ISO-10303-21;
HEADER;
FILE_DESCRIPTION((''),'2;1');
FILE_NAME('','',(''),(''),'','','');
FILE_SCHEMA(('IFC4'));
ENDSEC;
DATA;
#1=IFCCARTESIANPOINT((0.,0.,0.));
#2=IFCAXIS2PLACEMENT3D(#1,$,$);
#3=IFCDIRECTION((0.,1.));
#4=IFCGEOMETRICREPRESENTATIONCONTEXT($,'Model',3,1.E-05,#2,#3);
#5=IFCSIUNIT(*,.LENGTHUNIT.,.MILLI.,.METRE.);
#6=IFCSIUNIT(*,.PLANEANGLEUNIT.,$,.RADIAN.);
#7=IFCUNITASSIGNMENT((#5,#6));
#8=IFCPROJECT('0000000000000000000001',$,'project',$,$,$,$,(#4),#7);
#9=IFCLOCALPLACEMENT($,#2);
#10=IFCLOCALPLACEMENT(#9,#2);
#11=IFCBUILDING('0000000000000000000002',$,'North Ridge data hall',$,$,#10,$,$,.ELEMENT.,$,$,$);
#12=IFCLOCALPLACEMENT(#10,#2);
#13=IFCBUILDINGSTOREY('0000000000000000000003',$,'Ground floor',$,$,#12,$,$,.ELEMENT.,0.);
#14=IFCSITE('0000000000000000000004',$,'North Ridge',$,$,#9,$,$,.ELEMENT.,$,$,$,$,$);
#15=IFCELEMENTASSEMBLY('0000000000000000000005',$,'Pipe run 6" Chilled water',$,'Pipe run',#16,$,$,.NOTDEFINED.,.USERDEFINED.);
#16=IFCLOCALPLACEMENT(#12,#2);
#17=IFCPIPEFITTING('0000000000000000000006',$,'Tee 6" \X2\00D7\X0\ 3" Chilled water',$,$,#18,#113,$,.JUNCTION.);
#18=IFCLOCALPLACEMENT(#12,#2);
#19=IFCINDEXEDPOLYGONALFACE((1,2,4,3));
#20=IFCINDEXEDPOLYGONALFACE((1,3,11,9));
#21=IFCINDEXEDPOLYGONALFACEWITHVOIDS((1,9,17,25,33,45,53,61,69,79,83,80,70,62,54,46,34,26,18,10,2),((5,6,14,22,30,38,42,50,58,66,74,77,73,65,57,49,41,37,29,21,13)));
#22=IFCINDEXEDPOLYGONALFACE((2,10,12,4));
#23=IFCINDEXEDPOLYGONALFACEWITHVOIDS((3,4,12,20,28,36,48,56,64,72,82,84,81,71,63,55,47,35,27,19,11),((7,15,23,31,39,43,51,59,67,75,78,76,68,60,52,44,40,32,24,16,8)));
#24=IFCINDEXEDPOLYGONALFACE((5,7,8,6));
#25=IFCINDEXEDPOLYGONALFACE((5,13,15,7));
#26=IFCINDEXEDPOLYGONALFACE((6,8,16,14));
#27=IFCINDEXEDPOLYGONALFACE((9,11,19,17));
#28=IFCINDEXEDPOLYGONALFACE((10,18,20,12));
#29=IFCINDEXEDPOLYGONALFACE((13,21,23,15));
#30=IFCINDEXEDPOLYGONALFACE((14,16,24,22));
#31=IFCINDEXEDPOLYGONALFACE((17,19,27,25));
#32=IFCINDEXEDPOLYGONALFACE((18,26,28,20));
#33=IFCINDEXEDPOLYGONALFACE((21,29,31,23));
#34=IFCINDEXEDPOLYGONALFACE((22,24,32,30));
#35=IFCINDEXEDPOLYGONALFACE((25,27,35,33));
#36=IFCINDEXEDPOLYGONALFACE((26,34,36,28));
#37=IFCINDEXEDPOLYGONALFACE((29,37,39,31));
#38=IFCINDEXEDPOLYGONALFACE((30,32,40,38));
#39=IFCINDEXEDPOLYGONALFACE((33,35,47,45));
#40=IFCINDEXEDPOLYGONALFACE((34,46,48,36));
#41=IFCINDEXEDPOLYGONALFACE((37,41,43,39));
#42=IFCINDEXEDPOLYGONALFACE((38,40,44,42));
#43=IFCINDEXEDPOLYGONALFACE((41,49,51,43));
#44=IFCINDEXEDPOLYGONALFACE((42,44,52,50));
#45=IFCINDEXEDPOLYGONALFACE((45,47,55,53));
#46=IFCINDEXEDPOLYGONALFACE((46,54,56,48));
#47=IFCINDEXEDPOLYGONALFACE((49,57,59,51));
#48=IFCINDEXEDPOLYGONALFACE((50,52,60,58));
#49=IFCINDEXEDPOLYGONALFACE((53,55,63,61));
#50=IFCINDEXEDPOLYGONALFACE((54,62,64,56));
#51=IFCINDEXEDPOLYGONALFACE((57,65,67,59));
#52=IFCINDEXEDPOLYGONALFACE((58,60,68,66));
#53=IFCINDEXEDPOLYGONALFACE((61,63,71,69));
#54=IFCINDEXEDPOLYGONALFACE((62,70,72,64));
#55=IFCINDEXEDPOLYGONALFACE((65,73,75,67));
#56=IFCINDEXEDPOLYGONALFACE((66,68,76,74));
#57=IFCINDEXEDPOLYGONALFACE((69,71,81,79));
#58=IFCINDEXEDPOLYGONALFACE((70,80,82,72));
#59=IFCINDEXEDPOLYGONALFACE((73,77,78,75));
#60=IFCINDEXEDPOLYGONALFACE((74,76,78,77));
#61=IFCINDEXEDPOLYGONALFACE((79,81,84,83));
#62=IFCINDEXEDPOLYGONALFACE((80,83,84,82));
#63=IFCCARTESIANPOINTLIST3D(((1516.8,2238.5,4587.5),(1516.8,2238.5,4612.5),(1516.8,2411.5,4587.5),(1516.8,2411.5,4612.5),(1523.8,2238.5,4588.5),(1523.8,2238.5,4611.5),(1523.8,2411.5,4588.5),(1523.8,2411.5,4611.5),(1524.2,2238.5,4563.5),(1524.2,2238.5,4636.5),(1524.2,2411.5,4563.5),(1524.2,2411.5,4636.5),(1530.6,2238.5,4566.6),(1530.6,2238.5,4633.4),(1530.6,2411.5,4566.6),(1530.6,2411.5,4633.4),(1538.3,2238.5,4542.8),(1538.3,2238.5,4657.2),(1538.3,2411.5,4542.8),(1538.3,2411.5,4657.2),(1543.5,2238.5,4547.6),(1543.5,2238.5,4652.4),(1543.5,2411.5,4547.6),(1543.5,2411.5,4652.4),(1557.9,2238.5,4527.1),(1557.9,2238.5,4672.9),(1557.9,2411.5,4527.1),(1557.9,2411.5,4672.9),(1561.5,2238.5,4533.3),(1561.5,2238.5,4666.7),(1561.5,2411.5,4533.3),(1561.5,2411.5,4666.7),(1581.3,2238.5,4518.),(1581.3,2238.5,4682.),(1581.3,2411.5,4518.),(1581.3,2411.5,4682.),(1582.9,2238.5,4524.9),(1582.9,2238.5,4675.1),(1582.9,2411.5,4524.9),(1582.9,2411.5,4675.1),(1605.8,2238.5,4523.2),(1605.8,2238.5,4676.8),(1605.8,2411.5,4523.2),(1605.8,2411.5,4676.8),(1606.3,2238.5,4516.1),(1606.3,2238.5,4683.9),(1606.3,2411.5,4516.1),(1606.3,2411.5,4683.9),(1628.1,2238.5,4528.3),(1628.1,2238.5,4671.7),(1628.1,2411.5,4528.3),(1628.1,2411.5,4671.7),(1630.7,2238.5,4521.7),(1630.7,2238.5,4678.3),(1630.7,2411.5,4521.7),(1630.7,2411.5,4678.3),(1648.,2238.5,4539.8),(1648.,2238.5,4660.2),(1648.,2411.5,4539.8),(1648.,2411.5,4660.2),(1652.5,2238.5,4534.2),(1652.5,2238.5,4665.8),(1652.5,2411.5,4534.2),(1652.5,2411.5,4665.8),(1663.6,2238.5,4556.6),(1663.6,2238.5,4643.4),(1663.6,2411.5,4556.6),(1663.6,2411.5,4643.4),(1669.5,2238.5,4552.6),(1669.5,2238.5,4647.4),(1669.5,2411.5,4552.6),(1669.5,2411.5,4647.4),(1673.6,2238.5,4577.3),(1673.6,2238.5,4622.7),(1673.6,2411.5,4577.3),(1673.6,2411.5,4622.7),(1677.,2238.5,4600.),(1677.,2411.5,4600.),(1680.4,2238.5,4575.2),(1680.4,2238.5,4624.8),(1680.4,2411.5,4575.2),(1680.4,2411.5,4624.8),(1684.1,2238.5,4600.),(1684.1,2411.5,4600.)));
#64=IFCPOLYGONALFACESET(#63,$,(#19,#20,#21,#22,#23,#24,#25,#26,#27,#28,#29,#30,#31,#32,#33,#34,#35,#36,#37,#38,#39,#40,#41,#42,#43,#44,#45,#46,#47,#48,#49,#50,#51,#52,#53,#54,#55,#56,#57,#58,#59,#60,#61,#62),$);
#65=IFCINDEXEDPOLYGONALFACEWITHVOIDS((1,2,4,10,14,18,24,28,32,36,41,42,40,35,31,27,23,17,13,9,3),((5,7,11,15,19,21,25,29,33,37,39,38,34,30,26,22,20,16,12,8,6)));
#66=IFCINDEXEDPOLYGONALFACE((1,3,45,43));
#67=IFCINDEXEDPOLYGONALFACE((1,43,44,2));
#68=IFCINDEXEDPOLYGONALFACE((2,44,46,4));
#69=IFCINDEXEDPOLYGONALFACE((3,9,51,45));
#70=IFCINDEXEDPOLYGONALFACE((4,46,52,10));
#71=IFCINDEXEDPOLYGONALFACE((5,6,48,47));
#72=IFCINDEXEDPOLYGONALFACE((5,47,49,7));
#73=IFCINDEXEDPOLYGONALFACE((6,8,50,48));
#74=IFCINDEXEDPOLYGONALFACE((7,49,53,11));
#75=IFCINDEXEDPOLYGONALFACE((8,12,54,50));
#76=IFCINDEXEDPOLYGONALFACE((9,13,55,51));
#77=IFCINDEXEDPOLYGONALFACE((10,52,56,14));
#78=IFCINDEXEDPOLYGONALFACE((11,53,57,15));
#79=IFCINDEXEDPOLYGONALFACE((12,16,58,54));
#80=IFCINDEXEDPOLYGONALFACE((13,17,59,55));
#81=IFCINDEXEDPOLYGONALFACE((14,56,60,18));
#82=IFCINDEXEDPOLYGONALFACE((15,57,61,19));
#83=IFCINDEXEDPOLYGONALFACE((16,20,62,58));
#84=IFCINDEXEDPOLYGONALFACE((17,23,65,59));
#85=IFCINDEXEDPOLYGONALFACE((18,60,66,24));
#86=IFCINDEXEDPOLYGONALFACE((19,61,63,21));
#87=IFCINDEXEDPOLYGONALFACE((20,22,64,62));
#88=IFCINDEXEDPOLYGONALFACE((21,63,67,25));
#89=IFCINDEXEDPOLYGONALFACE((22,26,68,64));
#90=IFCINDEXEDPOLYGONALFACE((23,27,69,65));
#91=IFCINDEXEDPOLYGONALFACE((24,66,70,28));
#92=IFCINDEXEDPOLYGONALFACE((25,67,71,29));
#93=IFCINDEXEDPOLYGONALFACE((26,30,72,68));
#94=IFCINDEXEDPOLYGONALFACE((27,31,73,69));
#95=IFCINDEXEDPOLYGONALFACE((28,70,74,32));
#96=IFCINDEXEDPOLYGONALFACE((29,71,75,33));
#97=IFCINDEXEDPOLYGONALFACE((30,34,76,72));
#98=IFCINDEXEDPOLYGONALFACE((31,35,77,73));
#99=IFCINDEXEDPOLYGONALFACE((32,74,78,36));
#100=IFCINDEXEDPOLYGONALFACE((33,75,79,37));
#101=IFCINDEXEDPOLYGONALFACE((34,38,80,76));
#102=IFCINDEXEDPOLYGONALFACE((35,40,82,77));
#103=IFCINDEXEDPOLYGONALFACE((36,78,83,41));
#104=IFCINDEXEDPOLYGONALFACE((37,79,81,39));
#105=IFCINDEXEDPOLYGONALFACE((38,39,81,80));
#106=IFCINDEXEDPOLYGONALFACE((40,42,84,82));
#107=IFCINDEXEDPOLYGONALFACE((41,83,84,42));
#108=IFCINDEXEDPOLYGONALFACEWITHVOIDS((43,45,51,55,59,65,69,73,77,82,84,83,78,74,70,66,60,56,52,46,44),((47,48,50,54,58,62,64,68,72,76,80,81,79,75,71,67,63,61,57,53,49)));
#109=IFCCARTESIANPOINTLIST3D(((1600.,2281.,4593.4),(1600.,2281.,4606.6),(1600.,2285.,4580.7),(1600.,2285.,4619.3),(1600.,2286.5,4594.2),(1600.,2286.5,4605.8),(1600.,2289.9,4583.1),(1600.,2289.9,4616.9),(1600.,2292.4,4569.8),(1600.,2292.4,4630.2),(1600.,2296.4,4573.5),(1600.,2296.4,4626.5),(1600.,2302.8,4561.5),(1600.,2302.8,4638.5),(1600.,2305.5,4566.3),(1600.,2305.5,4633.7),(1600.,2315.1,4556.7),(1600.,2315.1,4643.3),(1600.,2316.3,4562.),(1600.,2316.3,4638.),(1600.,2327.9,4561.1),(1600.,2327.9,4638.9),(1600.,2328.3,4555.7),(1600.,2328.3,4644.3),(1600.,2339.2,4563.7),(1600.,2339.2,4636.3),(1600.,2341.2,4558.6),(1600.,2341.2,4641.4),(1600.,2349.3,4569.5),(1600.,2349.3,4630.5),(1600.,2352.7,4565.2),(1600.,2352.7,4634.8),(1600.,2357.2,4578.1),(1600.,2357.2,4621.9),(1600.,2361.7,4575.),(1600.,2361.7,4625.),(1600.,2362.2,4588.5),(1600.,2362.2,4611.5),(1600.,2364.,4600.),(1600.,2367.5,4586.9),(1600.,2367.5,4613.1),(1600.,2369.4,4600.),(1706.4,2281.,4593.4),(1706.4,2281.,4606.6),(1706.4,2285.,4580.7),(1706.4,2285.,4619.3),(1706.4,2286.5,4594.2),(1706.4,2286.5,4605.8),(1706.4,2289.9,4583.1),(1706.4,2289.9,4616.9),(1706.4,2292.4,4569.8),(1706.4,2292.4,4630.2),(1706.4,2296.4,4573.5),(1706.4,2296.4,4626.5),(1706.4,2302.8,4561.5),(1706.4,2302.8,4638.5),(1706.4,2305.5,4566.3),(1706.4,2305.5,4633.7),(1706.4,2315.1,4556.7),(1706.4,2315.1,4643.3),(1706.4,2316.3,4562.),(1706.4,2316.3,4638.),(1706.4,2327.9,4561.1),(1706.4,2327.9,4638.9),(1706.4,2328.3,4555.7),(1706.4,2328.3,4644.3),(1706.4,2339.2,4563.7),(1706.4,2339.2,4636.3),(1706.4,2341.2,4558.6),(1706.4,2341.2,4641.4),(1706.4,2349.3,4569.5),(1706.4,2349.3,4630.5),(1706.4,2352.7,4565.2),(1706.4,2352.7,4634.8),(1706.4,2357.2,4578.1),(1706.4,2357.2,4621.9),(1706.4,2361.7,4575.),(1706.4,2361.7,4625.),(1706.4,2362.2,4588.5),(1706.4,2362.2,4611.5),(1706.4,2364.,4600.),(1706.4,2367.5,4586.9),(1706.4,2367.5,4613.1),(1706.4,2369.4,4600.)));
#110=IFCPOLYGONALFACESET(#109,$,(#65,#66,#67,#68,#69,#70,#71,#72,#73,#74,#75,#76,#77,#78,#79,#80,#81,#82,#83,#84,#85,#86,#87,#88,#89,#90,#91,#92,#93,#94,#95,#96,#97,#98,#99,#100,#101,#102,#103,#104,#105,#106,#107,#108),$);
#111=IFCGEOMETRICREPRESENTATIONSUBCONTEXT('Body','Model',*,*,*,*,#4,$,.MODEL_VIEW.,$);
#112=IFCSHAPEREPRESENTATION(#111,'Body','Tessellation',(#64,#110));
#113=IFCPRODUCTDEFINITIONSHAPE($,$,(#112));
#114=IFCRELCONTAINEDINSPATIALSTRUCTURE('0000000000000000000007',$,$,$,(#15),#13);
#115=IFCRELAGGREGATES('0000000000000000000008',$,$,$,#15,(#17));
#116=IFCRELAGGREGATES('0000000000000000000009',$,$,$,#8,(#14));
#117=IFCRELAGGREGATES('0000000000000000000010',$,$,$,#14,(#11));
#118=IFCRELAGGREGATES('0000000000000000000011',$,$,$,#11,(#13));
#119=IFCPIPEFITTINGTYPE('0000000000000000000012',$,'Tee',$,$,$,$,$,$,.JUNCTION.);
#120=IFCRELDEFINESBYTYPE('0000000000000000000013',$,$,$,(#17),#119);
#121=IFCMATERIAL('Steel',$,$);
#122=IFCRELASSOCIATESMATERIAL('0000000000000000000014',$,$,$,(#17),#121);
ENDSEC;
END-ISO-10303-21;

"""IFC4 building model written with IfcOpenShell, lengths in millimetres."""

from ifc_helpers import new_model, si_unit, direction, frame, origin, origin_with_axes, origin_2d, place, context, subcontext, project, spatial, hollow_circle, extrude, material, type_object, element, aggregate, save


model = new_model("IFC4")

# Units and contexts
model_context = context("Model", 3, precision=1e-05, world=origin(), true_north=direction((0.0, 1.0)))
body_context = subcontext(model_context, "Body", "Model", "MODEL_VIEW")
ifc_project = project(units=[si_unit("LENGTHUNIT", "METRE", prefix="MILLI"), si_unit("PLANEANGLEUNIT", "RADIAN")], contexts=[model_context])

# Site, building, storey
site_placement = place(None, origin())
site = spatial("IfcSite", under=ifc_project, at=site_placement, Name="North Ridge", CompositionType="ELEMENT")
building_placement = place(site_placement, origin())
building = spatial("IfcBuilding", under=site, at=building_placement, Name="North Ridge data hall", CompositionType="ELEMENT")
storey_placement = place(building_placement, origin())
storey = spatial("IfcBuildingStorey", under=building, at=storey_placement, Name="Ground floor", CompositionType="ELEMENT", Elevation=0.0)

# Element assembly
assembly_1_placement = place(storey_placement, origin_with_axes())
assembly_1 = element("IfcElementAssembly", 1, at=assembly_1_placement, inside=storey, Name="Pipe run 6\" Chilled water", ObjectType="Pipe run", AssemblyPlace="NOTDEFINED", PredefinedType="USERDEFINED")
ifc_material_1 = material(Name="Steel")

# Pipe fitting
pipe_fitting_type_1 = type_object("IfcPipeFittingType", Name="Tee", PredefinedType="JUNCTION")
pipe_fitting_1_placement = place(storey_placement, origin_with_axes())
pipe_fitting_1 = element("IfcPipeFitting", 2, at=pipe_fitting_1_placement, type_object=pipe_fitting_type_1, material=ifc_material_1, Name="Tee 6\" × 3\" Chilled water", PredefinedType="JUNCTION", context=body_context, shape_type="SweptSolid", body=[
    extrude(hollow_circle(Radius=84.1, WallThickness=7.1, at=origin_2d()), frame((1600.0, 2411.5, 4600.0), z_axis=(0.0, -1.0, 0.0), x_axis=(1.0, 0.0, 0.0)), (0.0, 0.0, 1.0), 173.0),
    extrude(hollow_circle(Radius=44.5, WallThickness=5.5, at=origin_2d()), frame((1600.0, 2325.0, 4600.0), z_axis=(1.0, 0.0, 0.0), x_axis=(0.0, 1.0, 0.0)), (0.0, 0.0, 1.0), 106.4),
])
aggregate(assembly_1, [pipe_fitting_1])

save(model, "model.ifc")
